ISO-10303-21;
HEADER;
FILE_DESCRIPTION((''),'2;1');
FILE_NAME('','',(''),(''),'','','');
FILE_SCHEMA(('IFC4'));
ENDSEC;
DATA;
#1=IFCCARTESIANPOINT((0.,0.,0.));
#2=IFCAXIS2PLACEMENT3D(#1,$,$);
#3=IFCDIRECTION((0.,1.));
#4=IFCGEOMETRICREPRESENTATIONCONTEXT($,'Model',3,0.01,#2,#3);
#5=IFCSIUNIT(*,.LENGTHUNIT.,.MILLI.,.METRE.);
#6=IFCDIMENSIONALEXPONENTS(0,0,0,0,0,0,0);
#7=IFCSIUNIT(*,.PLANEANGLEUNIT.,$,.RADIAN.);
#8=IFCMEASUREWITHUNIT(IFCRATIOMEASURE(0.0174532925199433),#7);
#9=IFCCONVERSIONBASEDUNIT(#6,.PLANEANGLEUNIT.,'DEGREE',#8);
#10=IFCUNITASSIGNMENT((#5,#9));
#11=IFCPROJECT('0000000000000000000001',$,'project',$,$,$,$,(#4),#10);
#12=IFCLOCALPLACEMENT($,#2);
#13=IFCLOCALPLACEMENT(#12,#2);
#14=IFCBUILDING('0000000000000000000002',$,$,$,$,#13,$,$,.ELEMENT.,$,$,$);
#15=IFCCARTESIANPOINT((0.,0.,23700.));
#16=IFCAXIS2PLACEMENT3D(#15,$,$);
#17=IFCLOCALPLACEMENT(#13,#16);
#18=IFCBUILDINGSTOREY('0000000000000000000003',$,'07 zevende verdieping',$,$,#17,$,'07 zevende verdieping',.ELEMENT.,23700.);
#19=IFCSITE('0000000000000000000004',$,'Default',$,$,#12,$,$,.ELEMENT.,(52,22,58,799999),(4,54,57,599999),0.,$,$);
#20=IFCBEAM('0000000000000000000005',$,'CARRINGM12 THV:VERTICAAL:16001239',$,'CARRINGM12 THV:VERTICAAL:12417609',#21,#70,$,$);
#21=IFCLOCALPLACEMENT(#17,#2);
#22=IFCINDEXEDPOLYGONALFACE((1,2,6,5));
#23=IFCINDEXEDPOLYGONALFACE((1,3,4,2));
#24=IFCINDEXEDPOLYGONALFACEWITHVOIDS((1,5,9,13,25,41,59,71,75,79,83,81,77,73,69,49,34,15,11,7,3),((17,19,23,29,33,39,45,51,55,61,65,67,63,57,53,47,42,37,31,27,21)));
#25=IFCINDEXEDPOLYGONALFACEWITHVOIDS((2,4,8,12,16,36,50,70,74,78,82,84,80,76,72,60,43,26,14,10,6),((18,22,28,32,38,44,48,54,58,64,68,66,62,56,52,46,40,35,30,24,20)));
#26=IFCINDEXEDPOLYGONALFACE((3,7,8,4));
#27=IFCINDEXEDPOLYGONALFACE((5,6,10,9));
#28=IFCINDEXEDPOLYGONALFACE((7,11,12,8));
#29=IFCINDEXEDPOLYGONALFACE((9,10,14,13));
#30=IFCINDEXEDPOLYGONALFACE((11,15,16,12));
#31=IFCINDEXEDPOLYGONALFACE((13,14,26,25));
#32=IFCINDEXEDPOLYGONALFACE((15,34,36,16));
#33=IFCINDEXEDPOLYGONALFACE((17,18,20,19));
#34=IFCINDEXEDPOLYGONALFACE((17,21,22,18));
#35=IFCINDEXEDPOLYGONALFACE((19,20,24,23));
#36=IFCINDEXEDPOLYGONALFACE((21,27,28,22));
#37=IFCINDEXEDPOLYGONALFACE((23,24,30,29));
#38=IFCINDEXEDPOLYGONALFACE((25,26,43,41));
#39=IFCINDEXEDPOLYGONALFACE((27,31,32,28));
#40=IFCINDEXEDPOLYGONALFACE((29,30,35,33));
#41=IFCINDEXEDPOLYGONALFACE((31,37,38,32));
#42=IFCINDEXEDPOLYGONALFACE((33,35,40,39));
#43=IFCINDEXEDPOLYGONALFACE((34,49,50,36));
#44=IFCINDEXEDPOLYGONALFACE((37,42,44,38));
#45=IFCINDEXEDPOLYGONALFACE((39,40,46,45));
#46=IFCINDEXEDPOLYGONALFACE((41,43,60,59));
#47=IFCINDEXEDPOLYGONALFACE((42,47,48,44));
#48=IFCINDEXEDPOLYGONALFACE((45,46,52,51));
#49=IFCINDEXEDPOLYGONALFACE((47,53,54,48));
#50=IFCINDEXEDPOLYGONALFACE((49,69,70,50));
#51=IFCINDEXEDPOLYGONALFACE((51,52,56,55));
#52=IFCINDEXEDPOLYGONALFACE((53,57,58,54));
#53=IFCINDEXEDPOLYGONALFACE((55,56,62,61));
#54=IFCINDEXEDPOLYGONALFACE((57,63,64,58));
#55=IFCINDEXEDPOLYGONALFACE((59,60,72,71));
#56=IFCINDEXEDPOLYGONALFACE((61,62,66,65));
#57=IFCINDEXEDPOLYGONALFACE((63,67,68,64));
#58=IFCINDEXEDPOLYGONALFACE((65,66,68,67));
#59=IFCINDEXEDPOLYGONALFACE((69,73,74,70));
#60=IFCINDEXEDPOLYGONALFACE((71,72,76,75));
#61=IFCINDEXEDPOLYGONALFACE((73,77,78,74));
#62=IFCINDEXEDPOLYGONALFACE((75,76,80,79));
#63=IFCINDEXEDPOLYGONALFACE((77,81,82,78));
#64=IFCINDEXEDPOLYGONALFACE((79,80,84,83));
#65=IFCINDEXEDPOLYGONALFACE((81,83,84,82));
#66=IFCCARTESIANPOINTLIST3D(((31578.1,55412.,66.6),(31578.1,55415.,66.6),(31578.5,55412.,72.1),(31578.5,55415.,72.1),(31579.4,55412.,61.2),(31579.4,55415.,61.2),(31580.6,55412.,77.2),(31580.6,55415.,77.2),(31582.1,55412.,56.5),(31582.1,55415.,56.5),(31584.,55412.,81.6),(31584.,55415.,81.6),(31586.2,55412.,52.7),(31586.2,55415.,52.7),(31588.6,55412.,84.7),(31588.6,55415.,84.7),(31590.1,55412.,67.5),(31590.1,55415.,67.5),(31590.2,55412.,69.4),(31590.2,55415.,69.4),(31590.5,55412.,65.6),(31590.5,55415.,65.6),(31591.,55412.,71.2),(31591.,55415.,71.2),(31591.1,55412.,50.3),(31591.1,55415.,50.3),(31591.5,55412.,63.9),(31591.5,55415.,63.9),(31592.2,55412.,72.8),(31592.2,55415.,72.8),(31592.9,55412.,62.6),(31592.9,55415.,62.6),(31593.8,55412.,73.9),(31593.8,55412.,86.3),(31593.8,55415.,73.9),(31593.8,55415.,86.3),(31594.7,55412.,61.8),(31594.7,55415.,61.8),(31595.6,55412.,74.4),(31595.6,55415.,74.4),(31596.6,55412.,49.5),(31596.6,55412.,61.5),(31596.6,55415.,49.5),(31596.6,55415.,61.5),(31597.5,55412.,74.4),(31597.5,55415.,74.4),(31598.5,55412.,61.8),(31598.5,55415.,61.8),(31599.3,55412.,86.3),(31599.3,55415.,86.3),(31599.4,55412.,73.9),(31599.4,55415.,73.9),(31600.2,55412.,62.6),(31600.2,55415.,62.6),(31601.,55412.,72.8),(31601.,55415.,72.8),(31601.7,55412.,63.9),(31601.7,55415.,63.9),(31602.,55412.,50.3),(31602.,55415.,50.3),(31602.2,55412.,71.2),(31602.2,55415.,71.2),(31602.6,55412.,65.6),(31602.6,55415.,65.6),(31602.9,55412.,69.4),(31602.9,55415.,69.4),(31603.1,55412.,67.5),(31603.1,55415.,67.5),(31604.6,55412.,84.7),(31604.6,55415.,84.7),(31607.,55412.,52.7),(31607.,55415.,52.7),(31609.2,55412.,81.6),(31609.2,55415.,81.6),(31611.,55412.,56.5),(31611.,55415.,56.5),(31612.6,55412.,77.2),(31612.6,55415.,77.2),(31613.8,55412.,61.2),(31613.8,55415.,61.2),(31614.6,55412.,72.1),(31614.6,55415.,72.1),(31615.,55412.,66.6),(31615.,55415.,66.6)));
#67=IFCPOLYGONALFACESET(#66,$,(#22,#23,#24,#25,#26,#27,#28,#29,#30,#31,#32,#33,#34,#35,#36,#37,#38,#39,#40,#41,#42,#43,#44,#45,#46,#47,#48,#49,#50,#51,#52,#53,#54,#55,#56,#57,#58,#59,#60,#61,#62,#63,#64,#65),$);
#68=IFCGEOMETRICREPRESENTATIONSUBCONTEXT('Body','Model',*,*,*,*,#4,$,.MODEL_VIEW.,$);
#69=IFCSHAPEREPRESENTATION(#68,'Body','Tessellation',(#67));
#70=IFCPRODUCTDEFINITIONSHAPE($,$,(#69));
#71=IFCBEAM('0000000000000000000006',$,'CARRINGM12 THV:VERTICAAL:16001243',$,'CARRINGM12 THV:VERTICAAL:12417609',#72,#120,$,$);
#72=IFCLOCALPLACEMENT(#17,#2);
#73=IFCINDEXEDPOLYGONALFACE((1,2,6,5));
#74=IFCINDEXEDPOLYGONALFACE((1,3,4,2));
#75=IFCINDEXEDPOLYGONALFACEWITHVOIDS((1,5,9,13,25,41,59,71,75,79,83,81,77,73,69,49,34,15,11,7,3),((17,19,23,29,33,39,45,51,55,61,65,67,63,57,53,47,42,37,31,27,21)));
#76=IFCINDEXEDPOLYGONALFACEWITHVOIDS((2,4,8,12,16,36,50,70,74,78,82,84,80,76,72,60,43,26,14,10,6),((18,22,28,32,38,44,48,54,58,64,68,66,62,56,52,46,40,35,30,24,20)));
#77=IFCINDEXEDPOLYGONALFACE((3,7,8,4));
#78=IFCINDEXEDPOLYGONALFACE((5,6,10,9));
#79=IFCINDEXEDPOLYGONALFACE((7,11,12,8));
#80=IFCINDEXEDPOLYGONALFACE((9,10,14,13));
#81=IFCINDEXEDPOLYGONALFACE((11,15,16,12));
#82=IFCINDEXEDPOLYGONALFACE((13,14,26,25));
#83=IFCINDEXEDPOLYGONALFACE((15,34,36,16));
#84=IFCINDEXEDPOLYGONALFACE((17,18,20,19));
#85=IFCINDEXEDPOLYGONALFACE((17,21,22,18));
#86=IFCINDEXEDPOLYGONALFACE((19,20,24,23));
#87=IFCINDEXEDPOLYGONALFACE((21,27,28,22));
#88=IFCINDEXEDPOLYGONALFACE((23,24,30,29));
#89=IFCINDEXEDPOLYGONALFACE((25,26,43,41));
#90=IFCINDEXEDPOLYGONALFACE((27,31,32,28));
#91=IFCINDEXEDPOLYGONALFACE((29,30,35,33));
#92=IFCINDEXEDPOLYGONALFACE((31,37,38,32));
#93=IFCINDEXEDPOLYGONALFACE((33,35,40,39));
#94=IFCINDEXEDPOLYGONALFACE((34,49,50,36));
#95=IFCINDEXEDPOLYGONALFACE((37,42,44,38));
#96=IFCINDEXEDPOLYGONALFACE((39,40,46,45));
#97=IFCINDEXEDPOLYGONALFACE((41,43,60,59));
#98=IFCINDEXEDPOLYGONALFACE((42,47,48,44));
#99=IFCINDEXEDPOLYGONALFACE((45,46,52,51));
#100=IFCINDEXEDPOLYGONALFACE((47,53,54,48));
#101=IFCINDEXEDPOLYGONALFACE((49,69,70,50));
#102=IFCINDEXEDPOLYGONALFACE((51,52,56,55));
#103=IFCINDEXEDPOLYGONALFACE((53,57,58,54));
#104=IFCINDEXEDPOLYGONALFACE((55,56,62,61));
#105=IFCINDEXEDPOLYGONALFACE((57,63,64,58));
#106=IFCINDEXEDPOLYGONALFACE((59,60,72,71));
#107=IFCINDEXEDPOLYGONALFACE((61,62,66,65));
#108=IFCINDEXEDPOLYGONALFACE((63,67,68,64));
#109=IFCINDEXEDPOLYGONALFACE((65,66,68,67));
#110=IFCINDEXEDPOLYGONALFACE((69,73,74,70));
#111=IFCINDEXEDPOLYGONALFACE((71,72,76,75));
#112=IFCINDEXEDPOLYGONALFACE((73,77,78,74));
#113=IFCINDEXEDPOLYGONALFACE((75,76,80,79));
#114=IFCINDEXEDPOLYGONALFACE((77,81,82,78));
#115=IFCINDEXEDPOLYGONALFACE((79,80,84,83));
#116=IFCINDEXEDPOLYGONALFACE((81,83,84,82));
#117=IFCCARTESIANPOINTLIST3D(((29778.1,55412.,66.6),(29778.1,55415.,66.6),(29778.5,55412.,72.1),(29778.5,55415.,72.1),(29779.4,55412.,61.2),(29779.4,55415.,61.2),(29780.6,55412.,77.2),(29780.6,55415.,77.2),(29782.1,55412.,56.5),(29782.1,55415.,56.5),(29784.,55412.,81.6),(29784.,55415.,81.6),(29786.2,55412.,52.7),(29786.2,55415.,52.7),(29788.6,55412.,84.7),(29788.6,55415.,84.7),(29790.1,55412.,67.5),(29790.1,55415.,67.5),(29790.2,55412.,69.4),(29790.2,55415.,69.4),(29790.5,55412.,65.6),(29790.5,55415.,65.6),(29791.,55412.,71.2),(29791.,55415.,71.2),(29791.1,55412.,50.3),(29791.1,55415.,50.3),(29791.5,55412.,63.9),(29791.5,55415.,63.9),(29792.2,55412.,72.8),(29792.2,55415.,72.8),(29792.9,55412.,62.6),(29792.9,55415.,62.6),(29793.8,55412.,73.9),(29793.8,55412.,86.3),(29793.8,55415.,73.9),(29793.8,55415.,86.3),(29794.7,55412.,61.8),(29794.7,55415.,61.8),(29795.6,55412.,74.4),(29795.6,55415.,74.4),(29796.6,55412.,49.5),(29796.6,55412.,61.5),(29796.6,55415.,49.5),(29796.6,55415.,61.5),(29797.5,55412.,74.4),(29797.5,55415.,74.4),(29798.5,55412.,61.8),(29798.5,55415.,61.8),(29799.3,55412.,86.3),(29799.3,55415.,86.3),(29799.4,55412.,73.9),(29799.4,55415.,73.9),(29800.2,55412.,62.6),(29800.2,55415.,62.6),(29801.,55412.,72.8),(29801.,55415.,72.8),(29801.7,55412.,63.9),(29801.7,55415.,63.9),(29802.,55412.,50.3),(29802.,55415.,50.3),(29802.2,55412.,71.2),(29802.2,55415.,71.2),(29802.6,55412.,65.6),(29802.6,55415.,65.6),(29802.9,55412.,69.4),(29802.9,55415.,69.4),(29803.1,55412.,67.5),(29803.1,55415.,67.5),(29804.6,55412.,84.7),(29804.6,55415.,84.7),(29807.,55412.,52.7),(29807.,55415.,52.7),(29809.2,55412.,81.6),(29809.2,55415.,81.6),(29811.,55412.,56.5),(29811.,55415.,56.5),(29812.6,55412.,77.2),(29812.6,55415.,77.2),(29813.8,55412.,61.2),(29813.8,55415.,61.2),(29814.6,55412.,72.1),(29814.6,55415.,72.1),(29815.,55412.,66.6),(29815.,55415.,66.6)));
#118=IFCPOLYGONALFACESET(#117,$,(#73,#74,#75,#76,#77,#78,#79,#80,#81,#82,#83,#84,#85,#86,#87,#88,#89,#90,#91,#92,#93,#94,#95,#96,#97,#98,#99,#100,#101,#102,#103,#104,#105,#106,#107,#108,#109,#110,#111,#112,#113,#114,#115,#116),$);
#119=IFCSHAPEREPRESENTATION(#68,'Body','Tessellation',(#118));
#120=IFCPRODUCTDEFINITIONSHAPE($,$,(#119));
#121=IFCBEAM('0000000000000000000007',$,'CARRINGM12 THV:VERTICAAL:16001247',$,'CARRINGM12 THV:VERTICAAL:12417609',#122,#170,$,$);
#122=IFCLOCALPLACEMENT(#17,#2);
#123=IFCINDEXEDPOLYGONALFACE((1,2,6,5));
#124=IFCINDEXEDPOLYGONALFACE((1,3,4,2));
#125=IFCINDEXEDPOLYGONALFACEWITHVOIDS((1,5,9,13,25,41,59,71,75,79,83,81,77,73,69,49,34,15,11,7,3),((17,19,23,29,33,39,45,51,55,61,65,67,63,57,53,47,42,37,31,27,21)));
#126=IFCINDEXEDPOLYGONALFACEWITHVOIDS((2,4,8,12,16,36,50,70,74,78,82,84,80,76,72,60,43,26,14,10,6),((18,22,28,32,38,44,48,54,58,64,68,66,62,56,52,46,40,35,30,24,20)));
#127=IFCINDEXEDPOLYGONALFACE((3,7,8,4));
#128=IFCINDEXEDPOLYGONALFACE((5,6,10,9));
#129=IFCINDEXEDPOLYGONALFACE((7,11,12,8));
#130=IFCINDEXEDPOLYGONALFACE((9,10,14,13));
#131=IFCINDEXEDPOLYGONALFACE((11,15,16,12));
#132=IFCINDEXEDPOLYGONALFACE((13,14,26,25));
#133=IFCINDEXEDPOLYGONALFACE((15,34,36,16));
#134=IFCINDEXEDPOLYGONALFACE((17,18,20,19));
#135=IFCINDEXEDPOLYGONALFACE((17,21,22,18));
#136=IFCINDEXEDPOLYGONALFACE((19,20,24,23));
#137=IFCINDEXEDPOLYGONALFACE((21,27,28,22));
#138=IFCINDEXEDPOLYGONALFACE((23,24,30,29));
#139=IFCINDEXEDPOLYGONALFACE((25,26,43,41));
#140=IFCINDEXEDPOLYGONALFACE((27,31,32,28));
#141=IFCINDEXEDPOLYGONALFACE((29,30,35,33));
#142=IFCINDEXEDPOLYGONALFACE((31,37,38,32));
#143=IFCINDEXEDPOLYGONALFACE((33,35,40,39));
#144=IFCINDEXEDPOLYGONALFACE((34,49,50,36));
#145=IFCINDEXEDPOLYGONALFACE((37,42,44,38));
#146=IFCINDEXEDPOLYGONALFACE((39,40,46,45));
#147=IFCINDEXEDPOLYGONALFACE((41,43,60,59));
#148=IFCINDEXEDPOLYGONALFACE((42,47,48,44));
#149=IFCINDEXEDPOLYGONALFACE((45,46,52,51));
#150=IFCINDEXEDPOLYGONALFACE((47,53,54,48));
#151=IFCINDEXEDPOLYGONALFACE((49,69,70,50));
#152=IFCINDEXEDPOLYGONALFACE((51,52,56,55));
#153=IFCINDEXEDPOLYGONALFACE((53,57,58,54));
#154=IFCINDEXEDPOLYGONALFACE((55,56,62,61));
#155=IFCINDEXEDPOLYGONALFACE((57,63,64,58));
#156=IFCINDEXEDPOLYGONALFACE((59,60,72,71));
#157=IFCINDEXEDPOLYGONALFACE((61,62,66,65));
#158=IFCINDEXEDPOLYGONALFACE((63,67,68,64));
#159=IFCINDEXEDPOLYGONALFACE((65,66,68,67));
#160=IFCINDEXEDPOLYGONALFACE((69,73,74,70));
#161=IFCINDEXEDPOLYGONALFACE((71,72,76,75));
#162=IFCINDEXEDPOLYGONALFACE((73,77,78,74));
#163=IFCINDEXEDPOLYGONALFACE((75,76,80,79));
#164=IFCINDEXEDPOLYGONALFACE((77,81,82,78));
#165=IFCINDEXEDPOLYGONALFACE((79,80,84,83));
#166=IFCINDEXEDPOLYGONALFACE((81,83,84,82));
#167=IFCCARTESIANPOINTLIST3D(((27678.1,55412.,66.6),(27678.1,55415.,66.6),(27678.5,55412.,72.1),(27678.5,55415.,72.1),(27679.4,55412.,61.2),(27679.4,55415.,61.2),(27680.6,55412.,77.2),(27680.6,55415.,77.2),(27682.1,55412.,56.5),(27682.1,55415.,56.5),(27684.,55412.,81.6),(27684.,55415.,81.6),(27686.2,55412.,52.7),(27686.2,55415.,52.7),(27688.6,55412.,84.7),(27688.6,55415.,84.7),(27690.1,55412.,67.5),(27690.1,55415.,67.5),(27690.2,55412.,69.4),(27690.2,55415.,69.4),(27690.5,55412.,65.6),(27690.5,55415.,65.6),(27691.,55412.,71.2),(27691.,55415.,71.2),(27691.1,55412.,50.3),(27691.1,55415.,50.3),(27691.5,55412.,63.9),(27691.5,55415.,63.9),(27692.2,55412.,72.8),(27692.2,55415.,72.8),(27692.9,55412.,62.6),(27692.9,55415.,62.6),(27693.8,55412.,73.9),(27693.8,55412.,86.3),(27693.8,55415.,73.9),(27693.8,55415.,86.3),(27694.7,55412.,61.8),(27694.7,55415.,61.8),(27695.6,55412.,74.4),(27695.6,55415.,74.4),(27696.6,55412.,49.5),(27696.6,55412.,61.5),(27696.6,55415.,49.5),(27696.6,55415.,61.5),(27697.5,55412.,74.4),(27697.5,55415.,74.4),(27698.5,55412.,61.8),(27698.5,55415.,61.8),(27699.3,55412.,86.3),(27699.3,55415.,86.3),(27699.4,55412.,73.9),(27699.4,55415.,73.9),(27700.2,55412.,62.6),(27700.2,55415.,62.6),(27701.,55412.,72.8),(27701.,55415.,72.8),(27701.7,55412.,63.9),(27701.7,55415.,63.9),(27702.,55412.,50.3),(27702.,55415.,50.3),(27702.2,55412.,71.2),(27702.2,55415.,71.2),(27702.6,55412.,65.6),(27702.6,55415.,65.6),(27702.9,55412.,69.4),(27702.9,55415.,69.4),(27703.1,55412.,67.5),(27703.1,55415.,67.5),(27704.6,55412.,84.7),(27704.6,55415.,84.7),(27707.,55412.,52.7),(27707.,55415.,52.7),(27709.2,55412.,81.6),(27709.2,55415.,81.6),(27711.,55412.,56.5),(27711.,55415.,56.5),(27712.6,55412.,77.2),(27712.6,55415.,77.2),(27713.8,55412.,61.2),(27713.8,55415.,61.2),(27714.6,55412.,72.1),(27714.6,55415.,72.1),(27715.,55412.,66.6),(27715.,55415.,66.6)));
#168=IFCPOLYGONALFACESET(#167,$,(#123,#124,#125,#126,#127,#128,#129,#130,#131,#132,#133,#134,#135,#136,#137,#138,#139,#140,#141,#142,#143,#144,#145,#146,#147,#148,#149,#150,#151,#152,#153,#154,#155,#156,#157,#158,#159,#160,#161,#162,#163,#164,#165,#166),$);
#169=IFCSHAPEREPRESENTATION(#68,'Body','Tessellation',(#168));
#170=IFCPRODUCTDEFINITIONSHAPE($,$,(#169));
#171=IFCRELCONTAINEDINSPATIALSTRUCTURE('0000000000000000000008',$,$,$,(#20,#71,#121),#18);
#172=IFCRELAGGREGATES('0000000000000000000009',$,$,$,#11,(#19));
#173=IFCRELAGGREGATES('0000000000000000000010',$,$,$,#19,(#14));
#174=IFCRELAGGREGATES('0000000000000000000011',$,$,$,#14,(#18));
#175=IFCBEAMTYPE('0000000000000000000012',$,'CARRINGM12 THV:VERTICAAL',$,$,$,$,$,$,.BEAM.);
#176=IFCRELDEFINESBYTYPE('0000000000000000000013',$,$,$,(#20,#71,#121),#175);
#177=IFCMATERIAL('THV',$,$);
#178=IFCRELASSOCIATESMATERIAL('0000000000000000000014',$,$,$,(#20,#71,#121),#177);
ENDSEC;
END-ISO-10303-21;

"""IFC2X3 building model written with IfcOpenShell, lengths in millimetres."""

from ifc_helpers import new_model, entity, si_unit, converted_unit, direction, frame, origin, origin_2d_with_axis, place, context, subcontext, project, spatial, hollow_circle, extrude, material, type_object, element, save


model = new_model("IFC2X3")

# Units and contexts
model_context = context("Model", 3, precision=0.01, world=origin(), true_north=direction((0.0, 1.0)))
body_context = subcontext(model_context, "Body", "Model", "MODEL_VIEW")
ifc_project = project(units=[si_unit("LENGTHUNIT", "METRE", prefix="MILLI"), converted_unit("PLANEANGLEUNIT", "DEGREE", entity("IfcRatioMeasure", 0.0174532925199433), si_unit("PLANEANGLEUNIT", "RADIAN"), dimensions=[0, 0, 0, 0, 0, 0, 0])], contexts=[model_context])

# Site, building, storey
site_placement = place(None, origin())
site = spatial("IfcSite", under=ifc_project, at=site_placement, Name="Default", CompositionType="ELEMENT", RefLatitude=(52, 22, 58, 799999), RefLongitude=(4, 54, 57, 599999), RefElevation=0.0)
building_placement = place(site_placement, origin())
building = spatial("IfcBuilding", under=site, at=building_placement, CompositionType="ELEMENT")
storey_placement = place(building_placement, frame((0.0, 0.0, 23700.0)))
storey = spatial("IfcBuildingStorey", under=building, at=storey_placement, Name="07 zevende verdieping", LongName="07 zevende verdieping", CompositionType="ELEMENT", Elevation=23700.0)

# Beams
ifc_material = material(Name="THV")
beam_type = type_object("IfcBeamType", Name="CARRINGM12 THV:VERTICAAL", PredefinedType="BEAM")
beam_1_placement = place(storey_placement, origin())
element("IfcBeam", 1, at=beam_1_placement, inside=storey, type_object=beam_type, material=ifc_material, Name="CARRINGM12 THV:VERTICAAL:16001239", ObjectType="CARRINGM12 THV:VERTICAAL:12417609", context=body_context, shape_type="SweptSolid", body=[
    extrude(hollow_circle(Radius=18.5, WallThickness=12.0, at=origin_2d_with_axis()), frame((31596.6, 55412.0, 68.0), z_axis=(0.0, 1.0, 0.0), x_axis=(0.0, 0.0, -1.0)), (0.0, 0.0, 1.0), 3.0),
])
beam_2_placement = place(storey_placement, origin())
element("IfcBeam", 2, at=beam_2_placement, inside=storey, type_object=beam_type, material=ifc_material, Name="CARRINGM12 THV:VERTICAAL:16001243", ObjectType="CARRINGM12 THV:VERTICAAL:12417609", context=body_context, shape_type="SweptSolid", body=[
    extrude(hollow_circle(Radius=18.5, WallThickness=12.0, at=origin_2d_with_axis()), frame((29796.6, 55412.0, 68.0), z_axis=(0.0, 1.0, 0.0), x_axis=(0.0, 0.0, -1.0)), (0.0, 0.0, 1.0), 3.0),
])
beam_3_placement = place(storey_placement, origin())
element("IfcBeam", 3, at=beam_3_placement, inside=storey, type_object=beam_type, material=ifc_material, Name="CARRINGM12 THV:VERTICAAL:16001247", ObjectType="CARRINGM12 THV:VERTICAAL:12417609", context=body_context, shape_type="SweptSolid", body=[
    extrude(hollow_circle(Radius=18.5, WallThickness=12.0, at=origin_2d_with_axis()), frame((27696.6, 55412.0, 68.0), z_axis=(0.0, 1.0, 0.0), x_axis=(0.0, 0.0, -1.0)), (0.0, 0.0, 1.0), 3.0),
])

save(model, "model.ifc")
